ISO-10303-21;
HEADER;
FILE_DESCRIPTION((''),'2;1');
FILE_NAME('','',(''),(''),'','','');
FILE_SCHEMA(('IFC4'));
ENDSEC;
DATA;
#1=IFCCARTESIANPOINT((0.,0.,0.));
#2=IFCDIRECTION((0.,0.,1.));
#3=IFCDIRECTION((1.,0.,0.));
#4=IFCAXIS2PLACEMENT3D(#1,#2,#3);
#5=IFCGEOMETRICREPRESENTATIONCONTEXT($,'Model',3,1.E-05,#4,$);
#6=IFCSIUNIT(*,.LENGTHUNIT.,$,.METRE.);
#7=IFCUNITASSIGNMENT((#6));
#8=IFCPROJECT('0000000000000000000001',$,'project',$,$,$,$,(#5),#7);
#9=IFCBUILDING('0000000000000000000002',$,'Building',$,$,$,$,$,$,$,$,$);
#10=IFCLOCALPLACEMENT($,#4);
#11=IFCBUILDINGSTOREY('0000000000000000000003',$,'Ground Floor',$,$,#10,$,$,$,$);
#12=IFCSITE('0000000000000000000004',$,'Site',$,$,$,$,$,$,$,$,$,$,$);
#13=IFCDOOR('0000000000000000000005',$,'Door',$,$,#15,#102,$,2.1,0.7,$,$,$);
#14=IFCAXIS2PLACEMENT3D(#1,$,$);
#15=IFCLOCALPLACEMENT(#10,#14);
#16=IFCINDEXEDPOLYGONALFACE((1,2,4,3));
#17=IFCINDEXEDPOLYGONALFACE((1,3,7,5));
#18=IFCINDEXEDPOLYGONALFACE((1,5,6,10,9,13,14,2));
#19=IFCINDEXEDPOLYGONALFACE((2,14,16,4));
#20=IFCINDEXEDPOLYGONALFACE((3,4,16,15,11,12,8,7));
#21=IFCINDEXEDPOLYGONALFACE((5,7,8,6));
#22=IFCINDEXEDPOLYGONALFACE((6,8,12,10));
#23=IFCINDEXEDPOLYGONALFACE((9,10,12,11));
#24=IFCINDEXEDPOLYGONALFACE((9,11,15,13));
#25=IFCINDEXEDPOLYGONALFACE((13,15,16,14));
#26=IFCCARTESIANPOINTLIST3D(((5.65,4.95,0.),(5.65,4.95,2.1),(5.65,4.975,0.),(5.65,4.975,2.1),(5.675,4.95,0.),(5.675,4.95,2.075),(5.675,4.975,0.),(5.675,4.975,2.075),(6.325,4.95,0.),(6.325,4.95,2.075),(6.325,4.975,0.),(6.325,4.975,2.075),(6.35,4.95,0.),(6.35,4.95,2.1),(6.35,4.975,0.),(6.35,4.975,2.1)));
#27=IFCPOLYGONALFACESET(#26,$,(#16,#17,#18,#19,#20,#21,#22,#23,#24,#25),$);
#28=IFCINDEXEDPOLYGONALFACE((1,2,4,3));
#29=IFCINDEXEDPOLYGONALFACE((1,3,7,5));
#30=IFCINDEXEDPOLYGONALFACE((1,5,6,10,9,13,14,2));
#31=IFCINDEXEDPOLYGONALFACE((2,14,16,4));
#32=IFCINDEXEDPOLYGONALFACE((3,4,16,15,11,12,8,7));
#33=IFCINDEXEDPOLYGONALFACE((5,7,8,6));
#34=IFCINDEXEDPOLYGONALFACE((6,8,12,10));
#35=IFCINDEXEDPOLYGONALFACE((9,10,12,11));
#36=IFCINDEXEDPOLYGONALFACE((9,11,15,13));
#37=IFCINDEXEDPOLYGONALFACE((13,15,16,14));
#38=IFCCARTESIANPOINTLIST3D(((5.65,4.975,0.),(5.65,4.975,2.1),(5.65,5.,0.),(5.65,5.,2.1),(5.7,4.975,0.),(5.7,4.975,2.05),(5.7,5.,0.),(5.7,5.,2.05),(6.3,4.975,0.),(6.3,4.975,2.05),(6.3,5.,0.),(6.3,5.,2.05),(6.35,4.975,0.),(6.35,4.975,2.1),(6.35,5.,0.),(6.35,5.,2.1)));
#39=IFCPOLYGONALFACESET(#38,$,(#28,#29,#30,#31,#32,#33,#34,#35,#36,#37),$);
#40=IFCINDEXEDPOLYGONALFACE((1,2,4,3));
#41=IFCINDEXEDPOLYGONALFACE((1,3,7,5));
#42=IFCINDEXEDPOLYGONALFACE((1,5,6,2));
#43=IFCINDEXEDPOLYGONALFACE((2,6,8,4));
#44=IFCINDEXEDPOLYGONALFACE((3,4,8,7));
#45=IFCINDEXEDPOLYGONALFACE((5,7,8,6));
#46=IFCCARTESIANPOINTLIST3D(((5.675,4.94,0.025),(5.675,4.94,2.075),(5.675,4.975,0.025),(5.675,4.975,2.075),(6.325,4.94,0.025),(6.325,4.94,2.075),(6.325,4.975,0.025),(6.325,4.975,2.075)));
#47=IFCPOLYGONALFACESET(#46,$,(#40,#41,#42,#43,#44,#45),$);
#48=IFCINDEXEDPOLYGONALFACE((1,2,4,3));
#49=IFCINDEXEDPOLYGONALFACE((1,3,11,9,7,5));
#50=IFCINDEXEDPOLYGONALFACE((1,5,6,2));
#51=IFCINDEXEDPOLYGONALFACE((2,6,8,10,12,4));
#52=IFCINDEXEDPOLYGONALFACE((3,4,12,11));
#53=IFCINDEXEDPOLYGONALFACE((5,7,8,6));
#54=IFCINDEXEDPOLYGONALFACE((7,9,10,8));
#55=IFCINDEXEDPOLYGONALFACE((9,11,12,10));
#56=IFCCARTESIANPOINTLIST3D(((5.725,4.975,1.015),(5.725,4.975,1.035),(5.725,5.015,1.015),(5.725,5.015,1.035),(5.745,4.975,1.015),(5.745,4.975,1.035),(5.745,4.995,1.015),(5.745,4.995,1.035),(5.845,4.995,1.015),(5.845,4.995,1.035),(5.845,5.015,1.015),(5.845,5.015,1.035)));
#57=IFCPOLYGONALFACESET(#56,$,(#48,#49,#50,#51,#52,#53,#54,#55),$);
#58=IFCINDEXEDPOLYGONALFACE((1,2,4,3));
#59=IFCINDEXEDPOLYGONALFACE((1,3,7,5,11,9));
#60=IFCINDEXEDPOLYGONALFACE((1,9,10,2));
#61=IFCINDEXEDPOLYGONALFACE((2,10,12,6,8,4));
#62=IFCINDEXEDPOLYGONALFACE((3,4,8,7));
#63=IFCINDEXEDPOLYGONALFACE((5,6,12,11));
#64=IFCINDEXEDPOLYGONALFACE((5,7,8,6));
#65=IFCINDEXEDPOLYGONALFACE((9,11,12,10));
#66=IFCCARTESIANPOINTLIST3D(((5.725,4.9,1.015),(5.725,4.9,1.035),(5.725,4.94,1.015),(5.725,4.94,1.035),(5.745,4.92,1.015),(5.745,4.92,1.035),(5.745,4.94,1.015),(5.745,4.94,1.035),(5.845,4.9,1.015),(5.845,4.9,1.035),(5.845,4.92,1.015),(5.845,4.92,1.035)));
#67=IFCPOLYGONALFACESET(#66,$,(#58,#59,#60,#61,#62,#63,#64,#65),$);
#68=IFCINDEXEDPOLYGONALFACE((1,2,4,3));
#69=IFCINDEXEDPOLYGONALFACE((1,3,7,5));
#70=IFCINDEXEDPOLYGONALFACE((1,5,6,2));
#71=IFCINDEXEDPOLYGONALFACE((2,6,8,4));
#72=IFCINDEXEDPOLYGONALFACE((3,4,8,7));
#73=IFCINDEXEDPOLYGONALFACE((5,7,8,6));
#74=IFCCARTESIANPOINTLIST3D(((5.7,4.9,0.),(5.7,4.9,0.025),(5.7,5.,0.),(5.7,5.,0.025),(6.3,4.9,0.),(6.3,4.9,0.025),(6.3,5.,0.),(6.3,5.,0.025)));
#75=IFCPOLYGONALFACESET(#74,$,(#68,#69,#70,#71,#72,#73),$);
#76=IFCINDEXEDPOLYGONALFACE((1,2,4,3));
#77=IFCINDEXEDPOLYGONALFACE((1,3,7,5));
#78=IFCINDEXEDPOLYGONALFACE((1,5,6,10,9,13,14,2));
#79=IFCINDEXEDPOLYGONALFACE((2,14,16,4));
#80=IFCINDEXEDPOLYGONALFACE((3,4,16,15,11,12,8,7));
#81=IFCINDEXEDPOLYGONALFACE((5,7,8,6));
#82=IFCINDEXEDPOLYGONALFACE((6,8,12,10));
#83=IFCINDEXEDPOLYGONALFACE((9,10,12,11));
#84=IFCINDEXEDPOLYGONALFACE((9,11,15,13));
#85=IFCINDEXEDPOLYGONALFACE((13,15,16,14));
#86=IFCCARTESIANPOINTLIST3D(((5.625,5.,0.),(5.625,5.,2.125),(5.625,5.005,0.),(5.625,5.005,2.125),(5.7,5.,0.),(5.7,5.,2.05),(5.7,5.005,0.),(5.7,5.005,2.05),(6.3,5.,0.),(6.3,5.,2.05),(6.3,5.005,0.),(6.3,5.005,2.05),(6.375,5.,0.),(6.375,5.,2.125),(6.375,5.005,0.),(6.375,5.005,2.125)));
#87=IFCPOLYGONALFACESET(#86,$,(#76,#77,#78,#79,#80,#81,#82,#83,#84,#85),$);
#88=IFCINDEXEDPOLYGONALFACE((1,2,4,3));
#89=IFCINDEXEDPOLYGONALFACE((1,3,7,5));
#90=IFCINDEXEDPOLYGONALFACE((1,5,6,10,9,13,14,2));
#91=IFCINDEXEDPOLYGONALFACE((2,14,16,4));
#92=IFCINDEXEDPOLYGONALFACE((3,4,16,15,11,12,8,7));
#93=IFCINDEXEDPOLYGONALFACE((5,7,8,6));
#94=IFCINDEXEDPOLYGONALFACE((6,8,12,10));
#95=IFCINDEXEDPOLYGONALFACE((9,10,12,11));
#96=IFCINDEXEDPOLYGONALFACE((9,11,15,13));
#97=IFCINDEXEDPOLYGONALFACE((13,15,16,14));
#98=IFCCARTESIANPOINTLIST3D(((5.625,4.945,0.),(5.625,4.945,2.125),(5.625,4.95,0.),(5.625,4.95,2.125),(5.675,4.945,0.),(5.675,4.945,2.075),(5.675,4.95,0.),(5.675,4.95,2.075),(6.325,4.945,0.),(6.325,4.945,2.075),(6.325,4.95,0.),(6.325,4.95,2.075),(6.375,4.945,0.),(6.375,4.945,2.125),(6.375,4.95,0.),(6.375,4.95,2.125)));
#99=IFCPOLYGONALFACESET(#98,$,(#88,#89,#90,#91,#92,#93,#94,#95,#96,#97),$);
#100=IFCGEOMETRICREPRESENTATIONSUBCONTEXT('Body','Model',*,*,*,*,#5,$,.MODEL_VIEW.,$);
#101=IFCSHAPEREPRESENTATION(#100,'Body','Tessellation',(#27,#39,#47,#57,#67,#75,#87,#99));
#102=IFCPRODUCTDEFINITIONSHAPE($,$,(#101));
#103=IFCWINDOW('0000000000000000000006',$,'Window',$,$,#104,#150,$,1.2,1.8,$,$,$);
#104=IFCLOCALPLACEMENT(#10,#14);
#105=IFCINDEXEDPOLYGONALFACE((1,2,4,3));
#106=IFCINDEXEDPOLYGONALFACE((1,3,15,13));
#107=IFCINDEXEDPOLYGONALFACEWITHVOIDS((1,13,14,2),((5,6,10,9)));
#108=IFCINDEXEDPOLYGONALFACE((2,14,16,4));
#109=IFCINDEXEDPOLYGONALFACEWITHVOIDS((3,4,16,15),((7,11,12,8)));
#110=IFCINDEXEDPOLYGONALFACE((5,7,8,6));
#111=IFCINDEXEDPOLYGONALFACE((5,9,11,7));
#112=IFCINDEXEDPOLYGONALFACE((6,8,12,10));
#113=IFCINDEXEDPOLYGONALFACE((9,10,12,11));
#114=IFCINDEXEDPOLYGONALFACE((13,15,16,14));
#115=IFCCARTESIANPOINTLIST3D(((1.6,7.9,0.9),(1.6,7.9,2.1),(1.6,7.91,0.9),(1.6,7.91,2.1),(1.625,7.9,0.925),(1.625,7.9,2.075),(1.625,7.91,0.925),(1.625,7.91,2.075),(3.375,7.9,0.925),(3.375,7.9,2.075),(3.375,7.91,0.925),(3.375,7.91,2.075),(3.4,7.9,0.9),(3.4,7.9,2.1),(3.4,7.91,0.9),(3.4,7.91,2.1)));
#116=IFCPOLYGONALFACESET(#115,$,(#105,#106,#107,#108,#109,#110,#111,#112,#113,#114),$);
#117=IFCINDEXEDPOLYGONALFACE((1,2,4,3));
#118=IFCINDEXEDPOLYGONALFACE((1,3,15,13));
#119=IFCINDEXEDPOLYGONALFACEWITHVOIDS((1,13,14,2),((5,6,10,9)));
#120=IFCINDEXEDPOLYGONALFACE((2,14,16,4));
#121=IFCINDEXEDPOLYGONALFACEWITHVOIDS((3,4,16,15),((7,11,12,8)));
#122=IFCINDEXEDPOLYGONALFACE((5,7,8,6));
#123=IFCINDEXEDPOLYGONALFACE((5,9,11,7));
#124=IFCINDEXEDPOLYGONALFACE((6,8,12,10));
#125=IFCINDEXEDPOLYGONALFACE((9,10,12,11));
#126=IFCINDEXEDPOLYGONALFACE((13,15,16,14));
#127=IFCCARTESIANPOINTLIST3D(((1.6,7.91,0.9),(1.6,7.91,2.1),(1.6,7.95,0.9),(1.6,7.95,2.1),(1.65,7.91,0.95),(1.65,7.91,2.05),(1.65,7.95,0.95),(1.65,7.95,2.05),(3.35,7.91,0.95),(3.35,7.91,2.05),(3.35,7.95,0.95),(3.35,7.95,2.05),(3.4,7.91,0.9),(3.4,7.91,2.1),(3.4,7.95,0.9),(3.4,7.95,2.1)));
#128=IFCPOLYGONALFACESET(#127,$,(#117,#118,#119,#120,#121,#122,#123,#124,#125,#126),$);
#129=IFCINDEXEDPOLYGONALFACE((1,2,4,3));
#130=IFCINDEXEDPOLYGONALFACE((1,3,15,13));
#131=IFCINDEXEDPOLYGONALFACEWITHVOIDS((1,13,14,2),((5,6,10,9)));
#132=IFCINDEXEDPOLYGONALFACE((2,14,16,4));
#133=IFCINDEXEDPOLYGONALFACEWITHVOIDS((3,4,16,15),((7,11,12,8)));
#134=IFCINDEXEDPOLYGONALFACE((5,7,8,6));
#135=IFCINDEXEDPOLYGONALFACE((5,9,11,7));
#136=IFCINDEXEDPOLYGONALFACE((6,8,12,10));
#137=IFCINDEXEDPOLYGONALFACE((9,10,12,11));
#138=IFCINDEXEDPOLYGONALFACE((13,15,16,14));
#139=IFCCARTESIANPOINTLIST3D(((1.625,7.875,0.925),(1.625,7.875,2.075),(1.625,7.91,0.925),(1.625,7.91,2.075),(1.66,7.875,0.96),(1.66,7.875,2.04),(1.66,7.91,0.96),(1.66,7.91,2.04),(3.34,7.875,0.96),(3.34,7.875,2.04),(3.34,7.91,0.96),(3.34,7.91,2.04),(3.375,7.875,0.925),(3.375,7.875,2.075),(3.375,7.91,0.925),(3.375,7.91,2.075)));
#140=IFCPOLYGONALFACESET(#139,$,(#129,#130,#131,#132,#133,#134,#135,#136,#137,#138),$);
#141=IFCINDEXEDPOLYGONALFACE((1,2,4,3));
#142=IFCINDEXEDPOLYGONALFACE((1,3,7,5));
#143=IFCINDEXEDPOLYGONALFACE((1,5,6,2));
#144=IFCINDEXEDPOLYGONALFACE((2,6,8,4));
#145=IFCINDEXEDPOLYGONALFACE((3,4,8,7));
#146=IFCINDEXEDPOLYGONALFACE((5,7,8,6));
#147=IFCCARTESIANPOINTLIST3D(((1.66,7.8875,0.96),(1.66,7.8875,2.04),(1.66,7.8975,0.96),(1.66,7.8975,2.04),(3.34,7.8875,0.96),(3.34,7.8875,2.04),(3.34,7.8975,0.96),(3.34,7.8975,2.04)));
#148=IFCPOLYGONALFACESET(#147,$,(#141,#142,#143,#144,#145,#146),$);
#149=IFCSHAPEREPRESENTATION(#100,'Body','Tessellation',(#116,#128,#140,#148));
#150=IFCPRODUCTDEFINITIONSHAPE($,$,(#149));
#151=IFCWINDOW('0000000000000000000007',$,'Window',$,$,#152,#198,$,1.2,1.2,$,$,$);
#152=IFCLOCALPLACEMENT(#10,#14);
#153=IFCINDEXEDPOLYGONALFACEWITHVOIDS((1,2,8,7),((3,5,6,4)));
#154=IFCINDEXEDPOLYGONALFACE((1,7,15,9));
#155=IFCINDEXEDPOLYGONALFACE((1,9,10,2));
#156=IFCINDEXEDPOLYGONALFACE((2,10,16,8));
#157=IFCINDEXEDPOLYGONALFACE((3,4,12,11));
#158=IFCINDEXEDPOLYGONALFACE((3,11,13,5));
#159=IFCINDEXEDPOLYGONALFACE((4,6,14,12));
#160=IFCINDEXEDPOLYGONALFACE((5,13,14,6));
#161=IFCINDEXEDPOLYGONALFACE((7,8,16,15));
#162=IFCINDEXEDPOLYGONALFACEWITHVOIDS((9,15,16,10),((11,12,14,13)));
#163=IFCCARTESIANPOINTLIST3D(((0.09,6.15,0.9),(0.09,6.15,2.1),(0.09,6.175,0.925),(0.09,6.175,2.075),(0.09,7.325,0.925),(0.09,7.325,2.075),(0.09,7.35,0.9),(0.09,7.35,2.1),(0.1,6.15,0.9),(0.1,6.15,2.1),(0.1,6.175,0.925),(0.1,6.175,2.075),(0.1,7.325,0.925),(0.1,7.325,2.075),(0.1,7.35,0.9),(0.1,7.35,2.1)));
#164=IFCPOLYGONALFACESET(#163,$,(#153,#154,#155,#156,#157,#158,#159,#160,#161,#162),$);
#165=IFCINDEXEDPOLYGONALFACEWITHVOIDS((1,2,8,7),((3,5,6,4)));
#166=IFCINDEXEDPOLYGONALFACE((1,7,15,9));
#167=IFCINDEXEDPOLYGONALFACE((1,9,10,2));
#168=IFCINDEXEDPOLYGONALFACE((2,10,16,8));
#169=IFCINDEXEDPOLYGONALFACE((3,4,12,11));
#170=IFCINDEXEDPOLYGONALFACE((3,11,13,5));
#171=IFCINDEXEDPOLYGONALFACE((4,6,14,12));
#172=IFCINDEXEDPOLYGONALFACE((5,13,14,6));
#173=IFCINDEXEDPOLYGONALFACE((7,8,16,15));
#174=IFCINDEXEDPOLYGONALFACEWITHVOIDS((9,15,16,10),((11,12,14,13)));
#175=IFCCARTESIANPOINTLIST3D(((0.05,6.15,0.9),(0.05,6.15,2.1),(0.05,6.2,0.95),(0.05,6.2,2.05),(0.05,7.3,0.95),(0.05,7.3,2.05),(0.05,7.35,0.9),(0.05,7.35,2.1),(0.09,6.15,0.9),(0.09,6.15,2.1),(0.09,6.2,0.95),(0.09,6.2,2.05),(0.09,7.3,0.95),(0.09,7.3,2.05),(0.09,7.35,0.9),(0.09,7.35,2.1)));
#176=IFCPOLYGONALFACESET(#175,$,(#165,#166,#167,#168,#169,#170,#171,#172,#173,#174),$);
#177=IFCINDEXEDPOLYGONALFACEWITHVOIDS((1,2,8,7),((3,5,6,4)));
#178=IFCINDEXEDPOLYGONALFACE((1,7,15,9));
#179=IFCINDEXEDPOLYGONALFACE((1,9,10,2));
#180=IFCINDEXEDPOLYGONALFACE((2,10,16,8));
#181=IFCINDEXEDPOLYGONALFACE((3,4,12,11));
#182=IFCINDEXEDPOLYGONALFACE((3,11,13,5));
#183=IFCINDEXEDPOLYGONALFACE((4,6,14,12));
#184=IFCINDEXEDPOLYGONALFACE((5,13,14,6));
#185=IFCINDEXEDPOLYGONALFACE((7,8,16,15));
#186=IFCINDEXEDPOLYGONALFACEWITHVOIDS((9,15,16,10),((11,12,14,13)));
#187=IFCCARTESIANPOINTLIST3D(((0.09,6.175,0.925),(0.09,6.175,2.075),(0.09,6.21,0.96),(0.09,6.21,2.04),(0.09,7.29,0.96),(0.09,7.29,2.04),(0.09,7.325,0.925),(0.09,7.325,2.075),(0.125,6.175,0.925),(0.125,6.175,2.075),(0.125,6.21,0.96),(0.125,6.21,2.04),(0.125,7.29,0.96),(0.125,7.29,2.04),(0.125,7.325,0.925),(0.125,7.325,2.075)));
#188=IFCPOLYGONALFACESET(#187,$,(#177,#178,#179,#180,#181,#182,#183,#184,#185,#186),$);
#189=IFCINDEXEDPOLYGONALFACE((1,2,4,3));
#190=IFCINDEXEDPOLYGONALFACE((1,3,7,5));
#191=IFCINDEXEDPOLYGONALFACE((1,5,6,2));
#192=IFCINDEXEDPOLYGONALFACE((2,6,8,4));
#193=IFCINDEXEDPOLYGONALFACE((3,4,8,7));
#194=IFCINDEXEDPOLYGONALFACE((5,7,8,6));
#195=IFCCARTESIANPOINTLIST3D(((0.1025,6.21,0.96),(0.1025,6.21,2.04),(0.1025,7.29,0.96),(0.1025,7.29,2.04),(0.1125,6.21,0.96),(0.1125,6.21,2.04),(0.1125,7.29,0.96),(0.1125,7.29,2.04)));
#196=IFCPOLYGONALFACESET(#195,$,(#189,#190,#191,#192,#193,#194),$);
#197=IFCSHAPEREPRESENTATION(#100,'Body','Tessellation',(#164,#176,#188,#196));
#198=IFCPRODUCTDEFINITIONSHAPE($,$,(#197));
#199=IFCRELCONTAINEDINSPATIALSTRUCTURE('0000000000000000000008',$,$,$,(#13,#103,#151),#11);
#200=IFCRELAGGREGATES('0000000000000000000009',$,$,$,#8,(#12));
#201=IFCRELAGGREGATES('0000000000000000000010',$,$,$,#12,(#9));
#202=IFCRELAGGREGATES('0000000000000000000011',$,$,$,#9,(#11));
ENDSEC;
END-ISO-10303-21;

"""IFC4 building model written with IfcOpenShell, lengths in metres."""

from ifc_helpers import new_model, si_unit, frame, origin_with_axes, place, context, subcontext, project, spatial, line, indexed_curve, outline, extrude, element, save


model = new_model("IFC4")

# Units and contexts
model_context = context("Model", 3, precision=1e-05, world=origin_with_axes())
body_context = subcontext(model_context, "Body", "Model", "MODEL_VIEW")
ifc_project = project(units=[si_unit("LENGTHUNIT", "METRE")], contexts=[model_context])

# Site, building, storey
site = spatial("IfcSite", under=ifc_project, Name="Site")
building = spatial("IfcBuilding", under=site, Name="Building")
storey_placement = place(None, origin_with_axes())
storey = spatial("IfcBuildingStorey", under=building, at=storey_placement, Name="Ground Floor")

# Door
door_1_placement = place(storey_placement, frame((6.35, 5.0, 0.0), z_axis=(0.0, 0.0, 1.0), x_axis=(-1.0, 0.0, 0.0)))
element("IfcDoor", 1, at=door_1_placement, inside=storey, Name="Door", OverallHeight=2.1, OverallWidth=0.7, context=body_context, shape_type="SweptSolid", body=[
    extrude(outline(indexed_curve([(0.0, 0.0), (0.0, 2.1), (0.7, 2.1), (0.7, 0.0), (0.675, 0.0), (0.675, 2.075), (0.025, 2.075), (0.025, 0.0)], segments=[line(1, 2, 3, 4, 5, 6, 7, 8, 1)])), frame((0.0, 0.025, 0.0), z_axis=(0.0, -1.0, 0.0), x_axis=(1.0, 0.0, 0.0)), (0.0, 0.0, -1.0), 0.025),
    extrude(outline(indexed_curve([(0.0, 0.0), (0.0, 2.1), (0.7, 2.1), (0.7, 0.0), (0.65, 0.0), (0.65, 2.05), (0.05, 2.05), (0.05, 0.0)], segments=[line(1, 2, 3, 4, 5, 6, 7, 8, 1)])), frame((0.0, 0.0, 0.0), z_axis=(0.0, -1.0, 0.0), x_axis=(1.0, 0.0, 0.0)), (0.0, 0.0, -1.0), 0.025),
    extrude(outline(indexed_curve([(0.0, 0.0), (0.65, 0.0), (0.65, 0.035), (0.0, 0.035)], segments=[line(1, 2, 3, 4, 1)])), frame((0.025, 0.025, 0.025), z_axis=(0.0, 0.0, 1.0), x_axis=(1.0, 0.0, 0.0)), (0.0, 0.0, 1.0), 2.05),
    extrude(outline(indexed_curve([(0.0, 0.0), (0.0, -0.04), (-0.12, -0.04), (-0.12, -0.02), (-0.02, -0.02), (-0.02, 0.0)], segments=[line(1, 2, 3, 4, 5, 6, 1)])), frame((0.625, 0.025, 1.015), z_axis=(0.0, 0.0, 1.0), x_axis=(1.0, 0.0, 0.0)), (0.0, 0.0, 1.0), 0.02),
    extrude(outline(indexed_curve([(0.0, 0.0), (0.0, 0.04), (-0.12, 0.04), (-0.12, 0.02), (-0.02, 0.02), (-0.02, 0.0)], segments=[line(1, 2, 3, 4, 5, 6, 1)])), frame((0.625, 0.06, 1.015), z_axis=(0.0, 0.0, 1.0), x_axis=(1.0, 0.0, 0.0)), (0.0, 0.0, 1.0), 0.02),
    extrude(outline(indexed_curve([(0.0, 0.0), (0.6, 0.0), (0.6, 0.1), (0.0, 0.1)], segments=[line(1, 2, 3, 4, 1)])), frame((0.05, 0.0, 0.0), z_axis=(0.0, 0.0, 1.0), x_axis=(1.0, 0.0, 0.0)), (0.0, 0.0, 1.0), 0.025),
    extrude(outline(indexed_curve([(0.0, 0.0), (0.0, 2.125), (0.75, 2.125), (0.75, 0.0), (0.675, 0.0), (0.675, 2.05), (0.075, 2.05), (0.075, 0.0)], segments=[line(1, 2, 3, 4, 5, 6, 7, 8, 1)])), frame((-0.025, -0.005, 0.0), z_axis=(0.0, -1.0, 0.0), x_axis=(1.0, 0.0, 0.0)), (0.0, 0.0, -1.0), 0.005),
    extrude(outline(indexed_curve([(0.0, 0.0), (0.0, 2.125), (0.75, 2.125), (0.75, 0.0), (0.7, 0.0), (0.7, 2.075), (0.05, 2.075), (0.05, 0.0)], segments=[line(1, 2, 3, 4, 5, 6, 7, 8, 1)])), frame((-0.025, 0.05, 0.0), z_axis=(0.0, -1.0, 0.0), x_axis=(1.0, 0.0, 0.0)), (0.0, 0.0, -1.0), 0.005),
])

# Windows
window_1_placement = place(storey_placement, frame((3.4, 8.0, 0.9), z_axis=(0.0, 0.0, 1.0), x_axis=(-1.0, 0.0, 0.0)))
element("IfcWindow", 2, at=window_1_placement, inside=storey, Name="Window", OverallHeight=1.2, OverallWidth=1.8, context=body_context, shape_type="SweptSolid", body=[
    extrude(outline(indexed_curve([(0.0, 0.0), (1.8, 0.0), (1.8, 1.2), (0.0, 1.2)], segments=[line(1, 2, 3, 4, 1)]), holes=[indexed_curve([(0.025, 0.025), (1.775, 0.025), (1.775, 1.175), (0.025, 1.175)], segments=[line(1, 2, 3, 4, 1)])]), frame((0.0, 0.09, 0.0), z_axis=(0.0, -1.0, 0.0), x_axis=(1.0, 0.0, 0.0)), (0.0, 0.0, -1.0), 0.01),
    extrude(outline(indexed_curve([(0.0, 0.0), (1.8, 0.0), (1.8, 1.2), (0.0, 1.2)], segments=[line(1, 2, 3, 4, 1)]), holes=[indexed_curve([(0.05, 0.05), (1.75, 0.05), (1.75, 1.15), (0.05, 1.15)], segments=[line(1, 2, 3, 4, 1)])]), frame((0.0, 0.05, 0.0), z_axis=(0.0, -1.0, 0.0), x_axis=(1.0, 0.0, 0.0)), (0.0, 0.0, -1.0), 0.04),
    extrude(outline(indexed_curve([(0.0, 0.0), (1.75, 0.0), (1.75, 1.15), (0.0, 1.15)], segments=[line(1, 2, 3, 4, 1)]), holes=[indexed_curve([(0.035, 0.035), (1.715, 0.035), (1.715, 1.115), (0.035, 1.115)], segments=[line(1, 2, 3, 4, 1)])]), frame((0.025, 0.09, 0.025), z_axis=(0.0, -1.0, 0.0), x_axis=(1.0, 0.0, 0.0)), (0.0, 0.0, -1.0), 0.035),
    extrude(outline(indexed_curve([(0.035, 0.035), (1.715, 0.035), (1.715, 1.115), (0.035, 1.115)], segments=[line(1, 2, 3, 4, 1)])), frame((0.025, 0.1025, 0.025), z_axis=(0.0, -1.0, 0.0), x_axis=(1.0, 0.0, 0.0)), (0.0, 0.0, -1.0), 0.01),
])
window_2_placement = place(storey_placement, frame((0.0, 7.35, 0.9), z_axis=(0.0, 0.0, 1.0), x_axis=(0.0, -1.0, 0.0)))
element("IfcWindow", 3, at=window_2_placement, inside=storey, Name="Window", OverallHeight=1.2, OverallWidth=1.2, context=body_context, shape_type="SweptSolid", body=[
    extrude(outline(indexed_curve([(0.0, 0.0), (1.2, 0.0), (1.2, 1.2), (0.0, 1.2)], segments=[line(1, 2, 3, 4, 1)]), holes=[indexed_curve([(0.025, 0.025), (1.175, 0.025), (1.175, 1.175), (0.025, 1.175)], segments=[line(1, 2, 3, 4, 1)])]), frame((0.0, 0.09, 0.0), z_axis=(0.0, -1.0, 0.0), x_axis=(1.0, 0.0, 0.0)), (0.0, 0.0, -1.0), 0.01),
    extrude(outline(indexed_curve([(0.0, 0.0), (1.2, 0.0), (1.2, 1.2), (0.0, 1.2)], segments=[line(1, 2, 3, 4, 1)]), holes=[indexed_curve([(0.05, 0.05), (1.15, 0.05), (1.15, 1.15), (0.05, 1.15)], segments=[line(1, 2, 3, 4, 1)])]), frame((0.0, 0.05, 0.0), z_axis=(0.0, -1.0, 0.0), x_axis=(1.0, 0.0, 0.0)), (0.0, 0.0, -1.0), 0.04),
    extrude(outline(indexed_curve([(0.0, 0.0), (1.15, 0.0), (1.15, 1.15), (0.0, 1.15)], segments=[line(1, 2, 3, 4, 1)]), holes=[indexed_curve([(0.035, 0.035), (1.115, 0.035), (1.115, 1.115), (0.035, 1.115)], segments=[line(1, 2, 3, 4, 1)])]), frame((0.025, 0.09, 0.025), z_axis=(0.0, -1.0, 0.0), x_axis=(1.0, 0.0, 0.0)), (0.0, 0.0, -1.0), 0.035),
    extrude(outline(indexed_curve([(0.035, 0.035), (1.115, 0.035), (1.115, 1.115), (0.035, 1.115)], segments=[line(1, 2, 3, 4, 1)])), frame((0.025, 0.1025, 0.025), z_axis=(0.0, -1.0, 0.0), x_axis=(1.0, 0.0, 0.0)), (0.0, 0.0, -1.0), 0.01),
])

save(model, "model.ifc")
